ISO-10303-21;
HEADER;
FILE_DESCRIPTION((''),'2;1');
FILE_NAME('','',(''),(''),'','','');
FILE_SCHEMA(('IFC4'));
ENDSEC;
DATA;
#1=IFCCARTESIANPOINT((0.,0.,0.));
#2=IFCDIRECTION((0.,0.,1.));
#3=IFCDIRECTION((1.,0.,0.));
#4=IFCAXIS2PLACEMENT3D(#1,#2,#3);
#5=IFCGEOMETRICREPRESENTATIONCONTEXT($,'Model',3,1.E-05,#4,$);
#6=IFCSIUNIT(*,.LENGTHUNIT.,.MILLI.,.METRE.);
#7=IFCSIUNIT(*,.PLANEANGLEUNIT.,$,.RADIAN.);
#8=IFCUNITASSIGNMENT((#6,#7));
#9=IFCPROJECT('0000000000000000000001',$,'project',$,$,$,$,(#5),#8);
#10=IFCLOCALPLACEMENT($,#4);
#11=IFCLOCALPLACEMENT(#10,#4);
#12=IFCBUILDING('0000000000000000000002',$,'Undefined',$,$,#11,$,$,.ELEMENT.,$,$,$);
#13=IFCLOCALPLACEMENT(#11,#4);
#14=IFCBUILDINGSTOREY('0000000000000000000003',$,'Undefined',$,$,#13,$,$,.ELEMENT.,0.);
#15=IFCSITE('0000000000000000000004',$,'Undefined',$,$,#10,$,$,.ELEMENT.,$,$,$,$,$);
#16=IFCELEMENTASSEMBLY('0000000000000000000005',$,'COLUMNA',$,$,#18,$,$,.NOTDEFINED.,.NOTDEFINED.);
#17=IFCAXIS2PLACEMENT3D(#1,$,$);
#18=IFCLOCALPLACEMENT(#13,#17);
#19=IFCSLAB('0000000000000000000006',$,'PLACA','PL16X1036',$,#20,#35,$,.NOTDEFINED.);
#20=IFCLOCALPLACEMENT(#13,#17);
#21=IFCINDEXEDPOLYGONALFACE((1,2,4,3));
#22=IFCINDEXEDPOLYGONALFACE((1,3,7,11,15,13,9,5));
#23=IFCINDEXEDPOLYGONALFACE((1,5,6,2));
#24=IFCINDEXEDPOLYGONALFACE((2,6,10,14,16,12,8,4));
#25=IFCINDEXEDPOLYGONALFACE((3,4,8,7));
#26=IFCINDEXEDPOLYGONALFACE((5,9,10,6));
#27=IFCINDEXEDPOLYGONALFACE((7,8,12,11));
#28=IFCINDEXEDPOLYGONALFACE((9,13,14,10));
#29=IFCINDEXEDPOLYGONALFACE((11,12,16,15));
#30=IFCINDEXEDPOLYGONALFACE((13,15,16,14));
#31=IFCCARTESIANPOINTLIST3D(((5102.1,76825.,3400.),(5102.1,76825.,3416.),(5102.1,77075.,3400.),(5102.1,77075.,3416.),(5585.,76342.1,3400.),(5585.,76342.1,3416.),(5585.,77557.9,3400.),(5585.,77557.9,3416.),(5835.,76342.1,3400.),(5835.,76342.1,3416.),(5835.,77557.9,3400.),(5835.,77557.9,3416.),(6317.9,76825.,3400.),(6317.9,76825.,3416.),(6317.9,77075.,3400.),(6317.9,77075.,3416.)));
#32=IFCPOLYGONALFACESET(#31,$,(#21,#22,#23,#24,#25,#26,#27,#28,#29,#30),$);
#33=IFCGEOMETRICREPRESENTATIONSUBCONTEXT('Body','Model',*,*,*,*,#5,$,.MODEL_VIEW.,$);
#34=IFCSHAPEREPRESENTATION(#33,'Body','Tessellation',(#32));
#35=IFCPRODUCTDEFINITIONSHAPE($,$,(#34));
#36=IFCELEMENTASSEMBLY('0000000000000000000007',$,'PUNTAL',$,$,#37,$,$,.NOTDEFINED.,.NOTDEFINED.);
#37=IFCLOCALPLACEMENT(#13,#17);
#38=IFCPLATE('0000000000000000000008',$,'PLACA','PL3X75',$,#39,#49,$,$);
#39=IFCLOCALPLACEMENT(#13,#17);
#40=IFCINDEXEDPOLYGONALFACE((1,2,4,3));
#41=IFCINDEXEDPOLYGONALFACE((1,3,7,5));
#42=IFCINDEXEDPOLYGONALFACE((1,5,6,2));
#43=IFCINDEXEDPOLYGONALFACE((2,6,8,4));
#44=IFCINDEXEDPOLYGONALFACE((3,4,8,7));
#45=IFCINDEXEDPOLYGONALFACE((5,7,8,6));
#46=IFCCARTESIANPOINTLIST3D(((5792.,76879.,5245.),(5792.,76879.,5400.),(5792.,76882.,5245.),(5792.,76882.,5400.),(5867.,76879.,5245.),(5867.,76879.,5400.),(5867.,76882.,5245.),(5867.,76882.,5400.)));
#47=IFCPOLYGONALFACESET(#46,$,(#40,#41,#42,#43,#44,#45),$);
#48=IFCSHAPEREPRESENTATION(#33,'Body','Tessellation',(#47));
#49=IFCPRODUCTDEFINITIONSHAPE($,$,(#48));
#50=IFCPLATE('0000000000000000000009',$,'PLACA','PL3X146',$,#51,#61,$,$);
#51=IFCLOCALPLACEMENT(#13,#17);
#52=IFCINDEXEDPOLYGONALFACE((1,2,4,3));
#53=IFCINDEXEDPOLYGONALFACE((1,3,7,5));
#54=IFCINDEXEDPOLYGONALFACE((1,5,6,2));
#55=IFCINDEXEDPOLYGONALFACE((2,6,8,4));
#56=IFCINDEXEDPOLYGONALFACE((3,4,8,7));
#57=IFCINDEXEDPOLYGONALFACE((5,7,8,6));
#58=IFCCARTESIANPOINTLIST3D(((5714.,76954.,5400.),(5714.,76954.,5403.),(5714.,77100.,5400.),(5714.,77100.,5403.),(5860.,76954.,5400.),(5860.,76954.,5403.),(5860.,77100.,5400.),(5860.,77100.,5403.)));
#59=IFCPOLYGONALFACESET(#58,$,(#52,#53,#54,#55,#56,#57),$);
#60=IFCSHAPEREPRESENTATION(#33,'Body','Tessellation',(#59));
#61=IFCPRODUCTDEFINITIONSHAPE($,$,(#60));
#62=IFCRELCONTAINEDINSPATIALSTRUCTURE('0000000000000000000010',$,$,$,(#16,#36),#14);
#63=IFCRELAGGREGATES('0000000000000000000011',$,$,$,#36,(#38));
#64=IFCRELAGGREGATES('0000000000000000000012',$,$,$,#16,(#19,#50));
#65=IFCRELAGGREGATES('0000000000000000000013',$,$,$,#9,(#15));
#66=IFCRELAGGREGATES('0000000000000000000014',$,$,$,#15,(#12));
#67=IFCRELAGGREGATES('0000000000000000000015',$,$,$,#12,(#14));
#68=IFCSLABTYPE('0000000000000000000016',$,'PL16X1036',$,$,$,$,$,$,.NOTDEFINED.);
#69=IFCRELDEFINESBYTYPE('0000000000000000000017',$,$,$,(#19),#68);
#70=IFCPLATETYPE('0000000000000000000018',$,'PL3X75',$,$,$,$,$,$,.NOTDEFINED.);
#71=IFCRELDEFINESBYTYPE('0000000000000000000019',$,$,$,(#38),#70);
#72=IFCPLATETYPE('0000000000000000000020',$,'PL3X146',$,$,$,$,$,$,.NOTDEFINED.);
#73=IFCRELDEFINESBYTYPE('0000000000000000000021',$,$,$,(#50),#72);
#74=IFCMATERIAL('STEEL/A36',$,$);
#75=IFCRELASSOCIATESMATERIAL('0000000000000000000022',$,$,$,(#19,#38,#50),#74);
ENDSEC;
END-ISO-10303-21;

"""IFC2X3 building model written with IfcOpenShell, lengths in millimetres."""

from ifc_helpers import new_model, si_unit, frame, origin_with_axes, place, context, subcontext, project, spatial, polyline, outline, extrude, material, type_object, element, aggregate, save


model = new_model("IFC2X3")

# Units and contexts
model_context = context("Model", 3, precision=1e-05, world=origin_with_axes())
body_context = subcontext(model_context, "Body", "Model", "MODEL_VIEW")
ifc_project = project(units=[si_unit("LENGTHUNIT", "METRE", prefix="MILLI"), si_unit("PLANEANGLEUNIT", "RADIAN")], contexts=[model_context])

# Site, building, storey
site_placement = place(None, origin_with_axes())
site = spatial("IfcSite", under=ifc_project, at=site_placement, Name="Undefined", CompositionType="ELEMENT")
building_placement = place(site_placement, origin_with_axes())
building = spatial("IfcBuilding", under=site, at=building_placement, Name="Undefined", CompositionType="ELEMENT")
storey_placement = place(building_placement, origin_with_axes())
storey = spatial("IfcBuildingStorey", under=building, at=storey_placement, Name="Undefined", CompositionType="ELEMENT", Elevation=0.0)

# Element assembly
assembly_1_placement = place(storey_placement, origin_with_axes())
assembly_1 = element("IfcElementAssembly", 1, at=assembly_1_placement, inside=storey, Name="COLUMNA", AssemblyPlace="NOTDEFINED", PredefinedType="NOTDEFINED")
ifc_material_1 = material(Name="STEEL/A36")

# Slab
slab_type = type_object("IfcSlabType", Name="PL16X1036", PredefinedType="NOTDEFINED")
slab_placement = place(assembly_1_placement, frame((5835.0, 76342.1, 3408.0), z_axis=(0.0, 0.0, 1.0), x_axis=(0.707107, 0.707107, 0.0)))
slab = element("IfcSlab", 2, at=slab_placement, type_object=slab_type, material=ifc_material_1, Name="PLACA", Description="PL16X1036", PredefinedType="NOTDEFINED", context=body_context, shape_type="SweptSolid", body=[
    extrude(outline(polyline([(0.0, 0.0), (682.9, 0.0), (859.7, 176.8), (859.7, 859.7), (682.9, 1036.5), (0.0, 1036.5), (-176.8, 859.7), (-176.8, 176.8), (0.0, 0.0)])), frame((0.0, 0.0, -8.0), z_axis=(0.0, 0.0, 1.0), x_axis=(1.0, 0.0, 0.0)), (0.0, 0.0, 1.0), 16.0),
])

# Element assembly, plate
assembly_2_placement = place(storey_placement, origin_with_axes())
assembly_2 = element("IfcElementAssembly", 3, at=assembly_2_placement, inside=storey, Name="PUNTAL", AssemblyPlace="NOTDEFINED", PredefinedType="NOTDEFINED")
plate_type_1 = type_object("IfcPlateType", Name="PL3X75", PredefinedType="NOTDEFINED")
plate_1_placement = place(assembly_2_placement, frame((5867.0, 76880.5, 5245.0), z_axis=(0.0, 1.0, 0.0), x_axis=(-1.0, 0.0, 0.0)))
plate_1 = element("IfcPlate", 4, at=plate_1_placement, type_object=plate_type_1, material=ifc_material_1, Name="PLACA", Description="PL3X75", context=body_context, shape_type="SweptSolid", body=[
    extrude(outline(polyline([(0.0, 0.0), (75.0, 0.0), (75.0, 155.0), (0.0, 155.0), (0.0, 0.0)])), frame((0.0, 0.0, -1.5), z_axis=(0.0, 0.0, 1.0), x_axis=(1.0, 0.0, 0.0)), (0.0, 0.0, 1.0), 3.0),
])
aggregate(assembly_2, [plate_1])

# Plate
plate_type_2 = type_object("IfcPlateType", Name="PL3X146", PredefinedType="NOTDEFINED")
plate_2_placement = place(assembly_1_placement, frame((5860.0, 77100.0, 5401.5), z_axis=(0.0, 0.0, -1.0), x_axis=(0.0, -1.0, 0.0)))
plate_2 = element("IfcPlate", 5, at=plate_2_placement, type_object=plate_type_2, material=ifc_material_1, Name="PLACA", Description="PL3X146", context=body_context, shape_type="SweptSolid", body=[
    extrude(outline(polyline([(0.0, 0.0), (146.0, 0.0), (146.0, 146.0), (0.0, 146.0), (0.0, 0.0)])), frame((0.0, 0.0, -1.5), z_axis=(0.0, 0.0, 1.0), x_axis=(1.0, 0.0, 0.0)), (0.0, 0.0, 1.0), 3.0),
])
aggregate(assembly_1, [slab, plate_2])

save(model, "model.ifc")
